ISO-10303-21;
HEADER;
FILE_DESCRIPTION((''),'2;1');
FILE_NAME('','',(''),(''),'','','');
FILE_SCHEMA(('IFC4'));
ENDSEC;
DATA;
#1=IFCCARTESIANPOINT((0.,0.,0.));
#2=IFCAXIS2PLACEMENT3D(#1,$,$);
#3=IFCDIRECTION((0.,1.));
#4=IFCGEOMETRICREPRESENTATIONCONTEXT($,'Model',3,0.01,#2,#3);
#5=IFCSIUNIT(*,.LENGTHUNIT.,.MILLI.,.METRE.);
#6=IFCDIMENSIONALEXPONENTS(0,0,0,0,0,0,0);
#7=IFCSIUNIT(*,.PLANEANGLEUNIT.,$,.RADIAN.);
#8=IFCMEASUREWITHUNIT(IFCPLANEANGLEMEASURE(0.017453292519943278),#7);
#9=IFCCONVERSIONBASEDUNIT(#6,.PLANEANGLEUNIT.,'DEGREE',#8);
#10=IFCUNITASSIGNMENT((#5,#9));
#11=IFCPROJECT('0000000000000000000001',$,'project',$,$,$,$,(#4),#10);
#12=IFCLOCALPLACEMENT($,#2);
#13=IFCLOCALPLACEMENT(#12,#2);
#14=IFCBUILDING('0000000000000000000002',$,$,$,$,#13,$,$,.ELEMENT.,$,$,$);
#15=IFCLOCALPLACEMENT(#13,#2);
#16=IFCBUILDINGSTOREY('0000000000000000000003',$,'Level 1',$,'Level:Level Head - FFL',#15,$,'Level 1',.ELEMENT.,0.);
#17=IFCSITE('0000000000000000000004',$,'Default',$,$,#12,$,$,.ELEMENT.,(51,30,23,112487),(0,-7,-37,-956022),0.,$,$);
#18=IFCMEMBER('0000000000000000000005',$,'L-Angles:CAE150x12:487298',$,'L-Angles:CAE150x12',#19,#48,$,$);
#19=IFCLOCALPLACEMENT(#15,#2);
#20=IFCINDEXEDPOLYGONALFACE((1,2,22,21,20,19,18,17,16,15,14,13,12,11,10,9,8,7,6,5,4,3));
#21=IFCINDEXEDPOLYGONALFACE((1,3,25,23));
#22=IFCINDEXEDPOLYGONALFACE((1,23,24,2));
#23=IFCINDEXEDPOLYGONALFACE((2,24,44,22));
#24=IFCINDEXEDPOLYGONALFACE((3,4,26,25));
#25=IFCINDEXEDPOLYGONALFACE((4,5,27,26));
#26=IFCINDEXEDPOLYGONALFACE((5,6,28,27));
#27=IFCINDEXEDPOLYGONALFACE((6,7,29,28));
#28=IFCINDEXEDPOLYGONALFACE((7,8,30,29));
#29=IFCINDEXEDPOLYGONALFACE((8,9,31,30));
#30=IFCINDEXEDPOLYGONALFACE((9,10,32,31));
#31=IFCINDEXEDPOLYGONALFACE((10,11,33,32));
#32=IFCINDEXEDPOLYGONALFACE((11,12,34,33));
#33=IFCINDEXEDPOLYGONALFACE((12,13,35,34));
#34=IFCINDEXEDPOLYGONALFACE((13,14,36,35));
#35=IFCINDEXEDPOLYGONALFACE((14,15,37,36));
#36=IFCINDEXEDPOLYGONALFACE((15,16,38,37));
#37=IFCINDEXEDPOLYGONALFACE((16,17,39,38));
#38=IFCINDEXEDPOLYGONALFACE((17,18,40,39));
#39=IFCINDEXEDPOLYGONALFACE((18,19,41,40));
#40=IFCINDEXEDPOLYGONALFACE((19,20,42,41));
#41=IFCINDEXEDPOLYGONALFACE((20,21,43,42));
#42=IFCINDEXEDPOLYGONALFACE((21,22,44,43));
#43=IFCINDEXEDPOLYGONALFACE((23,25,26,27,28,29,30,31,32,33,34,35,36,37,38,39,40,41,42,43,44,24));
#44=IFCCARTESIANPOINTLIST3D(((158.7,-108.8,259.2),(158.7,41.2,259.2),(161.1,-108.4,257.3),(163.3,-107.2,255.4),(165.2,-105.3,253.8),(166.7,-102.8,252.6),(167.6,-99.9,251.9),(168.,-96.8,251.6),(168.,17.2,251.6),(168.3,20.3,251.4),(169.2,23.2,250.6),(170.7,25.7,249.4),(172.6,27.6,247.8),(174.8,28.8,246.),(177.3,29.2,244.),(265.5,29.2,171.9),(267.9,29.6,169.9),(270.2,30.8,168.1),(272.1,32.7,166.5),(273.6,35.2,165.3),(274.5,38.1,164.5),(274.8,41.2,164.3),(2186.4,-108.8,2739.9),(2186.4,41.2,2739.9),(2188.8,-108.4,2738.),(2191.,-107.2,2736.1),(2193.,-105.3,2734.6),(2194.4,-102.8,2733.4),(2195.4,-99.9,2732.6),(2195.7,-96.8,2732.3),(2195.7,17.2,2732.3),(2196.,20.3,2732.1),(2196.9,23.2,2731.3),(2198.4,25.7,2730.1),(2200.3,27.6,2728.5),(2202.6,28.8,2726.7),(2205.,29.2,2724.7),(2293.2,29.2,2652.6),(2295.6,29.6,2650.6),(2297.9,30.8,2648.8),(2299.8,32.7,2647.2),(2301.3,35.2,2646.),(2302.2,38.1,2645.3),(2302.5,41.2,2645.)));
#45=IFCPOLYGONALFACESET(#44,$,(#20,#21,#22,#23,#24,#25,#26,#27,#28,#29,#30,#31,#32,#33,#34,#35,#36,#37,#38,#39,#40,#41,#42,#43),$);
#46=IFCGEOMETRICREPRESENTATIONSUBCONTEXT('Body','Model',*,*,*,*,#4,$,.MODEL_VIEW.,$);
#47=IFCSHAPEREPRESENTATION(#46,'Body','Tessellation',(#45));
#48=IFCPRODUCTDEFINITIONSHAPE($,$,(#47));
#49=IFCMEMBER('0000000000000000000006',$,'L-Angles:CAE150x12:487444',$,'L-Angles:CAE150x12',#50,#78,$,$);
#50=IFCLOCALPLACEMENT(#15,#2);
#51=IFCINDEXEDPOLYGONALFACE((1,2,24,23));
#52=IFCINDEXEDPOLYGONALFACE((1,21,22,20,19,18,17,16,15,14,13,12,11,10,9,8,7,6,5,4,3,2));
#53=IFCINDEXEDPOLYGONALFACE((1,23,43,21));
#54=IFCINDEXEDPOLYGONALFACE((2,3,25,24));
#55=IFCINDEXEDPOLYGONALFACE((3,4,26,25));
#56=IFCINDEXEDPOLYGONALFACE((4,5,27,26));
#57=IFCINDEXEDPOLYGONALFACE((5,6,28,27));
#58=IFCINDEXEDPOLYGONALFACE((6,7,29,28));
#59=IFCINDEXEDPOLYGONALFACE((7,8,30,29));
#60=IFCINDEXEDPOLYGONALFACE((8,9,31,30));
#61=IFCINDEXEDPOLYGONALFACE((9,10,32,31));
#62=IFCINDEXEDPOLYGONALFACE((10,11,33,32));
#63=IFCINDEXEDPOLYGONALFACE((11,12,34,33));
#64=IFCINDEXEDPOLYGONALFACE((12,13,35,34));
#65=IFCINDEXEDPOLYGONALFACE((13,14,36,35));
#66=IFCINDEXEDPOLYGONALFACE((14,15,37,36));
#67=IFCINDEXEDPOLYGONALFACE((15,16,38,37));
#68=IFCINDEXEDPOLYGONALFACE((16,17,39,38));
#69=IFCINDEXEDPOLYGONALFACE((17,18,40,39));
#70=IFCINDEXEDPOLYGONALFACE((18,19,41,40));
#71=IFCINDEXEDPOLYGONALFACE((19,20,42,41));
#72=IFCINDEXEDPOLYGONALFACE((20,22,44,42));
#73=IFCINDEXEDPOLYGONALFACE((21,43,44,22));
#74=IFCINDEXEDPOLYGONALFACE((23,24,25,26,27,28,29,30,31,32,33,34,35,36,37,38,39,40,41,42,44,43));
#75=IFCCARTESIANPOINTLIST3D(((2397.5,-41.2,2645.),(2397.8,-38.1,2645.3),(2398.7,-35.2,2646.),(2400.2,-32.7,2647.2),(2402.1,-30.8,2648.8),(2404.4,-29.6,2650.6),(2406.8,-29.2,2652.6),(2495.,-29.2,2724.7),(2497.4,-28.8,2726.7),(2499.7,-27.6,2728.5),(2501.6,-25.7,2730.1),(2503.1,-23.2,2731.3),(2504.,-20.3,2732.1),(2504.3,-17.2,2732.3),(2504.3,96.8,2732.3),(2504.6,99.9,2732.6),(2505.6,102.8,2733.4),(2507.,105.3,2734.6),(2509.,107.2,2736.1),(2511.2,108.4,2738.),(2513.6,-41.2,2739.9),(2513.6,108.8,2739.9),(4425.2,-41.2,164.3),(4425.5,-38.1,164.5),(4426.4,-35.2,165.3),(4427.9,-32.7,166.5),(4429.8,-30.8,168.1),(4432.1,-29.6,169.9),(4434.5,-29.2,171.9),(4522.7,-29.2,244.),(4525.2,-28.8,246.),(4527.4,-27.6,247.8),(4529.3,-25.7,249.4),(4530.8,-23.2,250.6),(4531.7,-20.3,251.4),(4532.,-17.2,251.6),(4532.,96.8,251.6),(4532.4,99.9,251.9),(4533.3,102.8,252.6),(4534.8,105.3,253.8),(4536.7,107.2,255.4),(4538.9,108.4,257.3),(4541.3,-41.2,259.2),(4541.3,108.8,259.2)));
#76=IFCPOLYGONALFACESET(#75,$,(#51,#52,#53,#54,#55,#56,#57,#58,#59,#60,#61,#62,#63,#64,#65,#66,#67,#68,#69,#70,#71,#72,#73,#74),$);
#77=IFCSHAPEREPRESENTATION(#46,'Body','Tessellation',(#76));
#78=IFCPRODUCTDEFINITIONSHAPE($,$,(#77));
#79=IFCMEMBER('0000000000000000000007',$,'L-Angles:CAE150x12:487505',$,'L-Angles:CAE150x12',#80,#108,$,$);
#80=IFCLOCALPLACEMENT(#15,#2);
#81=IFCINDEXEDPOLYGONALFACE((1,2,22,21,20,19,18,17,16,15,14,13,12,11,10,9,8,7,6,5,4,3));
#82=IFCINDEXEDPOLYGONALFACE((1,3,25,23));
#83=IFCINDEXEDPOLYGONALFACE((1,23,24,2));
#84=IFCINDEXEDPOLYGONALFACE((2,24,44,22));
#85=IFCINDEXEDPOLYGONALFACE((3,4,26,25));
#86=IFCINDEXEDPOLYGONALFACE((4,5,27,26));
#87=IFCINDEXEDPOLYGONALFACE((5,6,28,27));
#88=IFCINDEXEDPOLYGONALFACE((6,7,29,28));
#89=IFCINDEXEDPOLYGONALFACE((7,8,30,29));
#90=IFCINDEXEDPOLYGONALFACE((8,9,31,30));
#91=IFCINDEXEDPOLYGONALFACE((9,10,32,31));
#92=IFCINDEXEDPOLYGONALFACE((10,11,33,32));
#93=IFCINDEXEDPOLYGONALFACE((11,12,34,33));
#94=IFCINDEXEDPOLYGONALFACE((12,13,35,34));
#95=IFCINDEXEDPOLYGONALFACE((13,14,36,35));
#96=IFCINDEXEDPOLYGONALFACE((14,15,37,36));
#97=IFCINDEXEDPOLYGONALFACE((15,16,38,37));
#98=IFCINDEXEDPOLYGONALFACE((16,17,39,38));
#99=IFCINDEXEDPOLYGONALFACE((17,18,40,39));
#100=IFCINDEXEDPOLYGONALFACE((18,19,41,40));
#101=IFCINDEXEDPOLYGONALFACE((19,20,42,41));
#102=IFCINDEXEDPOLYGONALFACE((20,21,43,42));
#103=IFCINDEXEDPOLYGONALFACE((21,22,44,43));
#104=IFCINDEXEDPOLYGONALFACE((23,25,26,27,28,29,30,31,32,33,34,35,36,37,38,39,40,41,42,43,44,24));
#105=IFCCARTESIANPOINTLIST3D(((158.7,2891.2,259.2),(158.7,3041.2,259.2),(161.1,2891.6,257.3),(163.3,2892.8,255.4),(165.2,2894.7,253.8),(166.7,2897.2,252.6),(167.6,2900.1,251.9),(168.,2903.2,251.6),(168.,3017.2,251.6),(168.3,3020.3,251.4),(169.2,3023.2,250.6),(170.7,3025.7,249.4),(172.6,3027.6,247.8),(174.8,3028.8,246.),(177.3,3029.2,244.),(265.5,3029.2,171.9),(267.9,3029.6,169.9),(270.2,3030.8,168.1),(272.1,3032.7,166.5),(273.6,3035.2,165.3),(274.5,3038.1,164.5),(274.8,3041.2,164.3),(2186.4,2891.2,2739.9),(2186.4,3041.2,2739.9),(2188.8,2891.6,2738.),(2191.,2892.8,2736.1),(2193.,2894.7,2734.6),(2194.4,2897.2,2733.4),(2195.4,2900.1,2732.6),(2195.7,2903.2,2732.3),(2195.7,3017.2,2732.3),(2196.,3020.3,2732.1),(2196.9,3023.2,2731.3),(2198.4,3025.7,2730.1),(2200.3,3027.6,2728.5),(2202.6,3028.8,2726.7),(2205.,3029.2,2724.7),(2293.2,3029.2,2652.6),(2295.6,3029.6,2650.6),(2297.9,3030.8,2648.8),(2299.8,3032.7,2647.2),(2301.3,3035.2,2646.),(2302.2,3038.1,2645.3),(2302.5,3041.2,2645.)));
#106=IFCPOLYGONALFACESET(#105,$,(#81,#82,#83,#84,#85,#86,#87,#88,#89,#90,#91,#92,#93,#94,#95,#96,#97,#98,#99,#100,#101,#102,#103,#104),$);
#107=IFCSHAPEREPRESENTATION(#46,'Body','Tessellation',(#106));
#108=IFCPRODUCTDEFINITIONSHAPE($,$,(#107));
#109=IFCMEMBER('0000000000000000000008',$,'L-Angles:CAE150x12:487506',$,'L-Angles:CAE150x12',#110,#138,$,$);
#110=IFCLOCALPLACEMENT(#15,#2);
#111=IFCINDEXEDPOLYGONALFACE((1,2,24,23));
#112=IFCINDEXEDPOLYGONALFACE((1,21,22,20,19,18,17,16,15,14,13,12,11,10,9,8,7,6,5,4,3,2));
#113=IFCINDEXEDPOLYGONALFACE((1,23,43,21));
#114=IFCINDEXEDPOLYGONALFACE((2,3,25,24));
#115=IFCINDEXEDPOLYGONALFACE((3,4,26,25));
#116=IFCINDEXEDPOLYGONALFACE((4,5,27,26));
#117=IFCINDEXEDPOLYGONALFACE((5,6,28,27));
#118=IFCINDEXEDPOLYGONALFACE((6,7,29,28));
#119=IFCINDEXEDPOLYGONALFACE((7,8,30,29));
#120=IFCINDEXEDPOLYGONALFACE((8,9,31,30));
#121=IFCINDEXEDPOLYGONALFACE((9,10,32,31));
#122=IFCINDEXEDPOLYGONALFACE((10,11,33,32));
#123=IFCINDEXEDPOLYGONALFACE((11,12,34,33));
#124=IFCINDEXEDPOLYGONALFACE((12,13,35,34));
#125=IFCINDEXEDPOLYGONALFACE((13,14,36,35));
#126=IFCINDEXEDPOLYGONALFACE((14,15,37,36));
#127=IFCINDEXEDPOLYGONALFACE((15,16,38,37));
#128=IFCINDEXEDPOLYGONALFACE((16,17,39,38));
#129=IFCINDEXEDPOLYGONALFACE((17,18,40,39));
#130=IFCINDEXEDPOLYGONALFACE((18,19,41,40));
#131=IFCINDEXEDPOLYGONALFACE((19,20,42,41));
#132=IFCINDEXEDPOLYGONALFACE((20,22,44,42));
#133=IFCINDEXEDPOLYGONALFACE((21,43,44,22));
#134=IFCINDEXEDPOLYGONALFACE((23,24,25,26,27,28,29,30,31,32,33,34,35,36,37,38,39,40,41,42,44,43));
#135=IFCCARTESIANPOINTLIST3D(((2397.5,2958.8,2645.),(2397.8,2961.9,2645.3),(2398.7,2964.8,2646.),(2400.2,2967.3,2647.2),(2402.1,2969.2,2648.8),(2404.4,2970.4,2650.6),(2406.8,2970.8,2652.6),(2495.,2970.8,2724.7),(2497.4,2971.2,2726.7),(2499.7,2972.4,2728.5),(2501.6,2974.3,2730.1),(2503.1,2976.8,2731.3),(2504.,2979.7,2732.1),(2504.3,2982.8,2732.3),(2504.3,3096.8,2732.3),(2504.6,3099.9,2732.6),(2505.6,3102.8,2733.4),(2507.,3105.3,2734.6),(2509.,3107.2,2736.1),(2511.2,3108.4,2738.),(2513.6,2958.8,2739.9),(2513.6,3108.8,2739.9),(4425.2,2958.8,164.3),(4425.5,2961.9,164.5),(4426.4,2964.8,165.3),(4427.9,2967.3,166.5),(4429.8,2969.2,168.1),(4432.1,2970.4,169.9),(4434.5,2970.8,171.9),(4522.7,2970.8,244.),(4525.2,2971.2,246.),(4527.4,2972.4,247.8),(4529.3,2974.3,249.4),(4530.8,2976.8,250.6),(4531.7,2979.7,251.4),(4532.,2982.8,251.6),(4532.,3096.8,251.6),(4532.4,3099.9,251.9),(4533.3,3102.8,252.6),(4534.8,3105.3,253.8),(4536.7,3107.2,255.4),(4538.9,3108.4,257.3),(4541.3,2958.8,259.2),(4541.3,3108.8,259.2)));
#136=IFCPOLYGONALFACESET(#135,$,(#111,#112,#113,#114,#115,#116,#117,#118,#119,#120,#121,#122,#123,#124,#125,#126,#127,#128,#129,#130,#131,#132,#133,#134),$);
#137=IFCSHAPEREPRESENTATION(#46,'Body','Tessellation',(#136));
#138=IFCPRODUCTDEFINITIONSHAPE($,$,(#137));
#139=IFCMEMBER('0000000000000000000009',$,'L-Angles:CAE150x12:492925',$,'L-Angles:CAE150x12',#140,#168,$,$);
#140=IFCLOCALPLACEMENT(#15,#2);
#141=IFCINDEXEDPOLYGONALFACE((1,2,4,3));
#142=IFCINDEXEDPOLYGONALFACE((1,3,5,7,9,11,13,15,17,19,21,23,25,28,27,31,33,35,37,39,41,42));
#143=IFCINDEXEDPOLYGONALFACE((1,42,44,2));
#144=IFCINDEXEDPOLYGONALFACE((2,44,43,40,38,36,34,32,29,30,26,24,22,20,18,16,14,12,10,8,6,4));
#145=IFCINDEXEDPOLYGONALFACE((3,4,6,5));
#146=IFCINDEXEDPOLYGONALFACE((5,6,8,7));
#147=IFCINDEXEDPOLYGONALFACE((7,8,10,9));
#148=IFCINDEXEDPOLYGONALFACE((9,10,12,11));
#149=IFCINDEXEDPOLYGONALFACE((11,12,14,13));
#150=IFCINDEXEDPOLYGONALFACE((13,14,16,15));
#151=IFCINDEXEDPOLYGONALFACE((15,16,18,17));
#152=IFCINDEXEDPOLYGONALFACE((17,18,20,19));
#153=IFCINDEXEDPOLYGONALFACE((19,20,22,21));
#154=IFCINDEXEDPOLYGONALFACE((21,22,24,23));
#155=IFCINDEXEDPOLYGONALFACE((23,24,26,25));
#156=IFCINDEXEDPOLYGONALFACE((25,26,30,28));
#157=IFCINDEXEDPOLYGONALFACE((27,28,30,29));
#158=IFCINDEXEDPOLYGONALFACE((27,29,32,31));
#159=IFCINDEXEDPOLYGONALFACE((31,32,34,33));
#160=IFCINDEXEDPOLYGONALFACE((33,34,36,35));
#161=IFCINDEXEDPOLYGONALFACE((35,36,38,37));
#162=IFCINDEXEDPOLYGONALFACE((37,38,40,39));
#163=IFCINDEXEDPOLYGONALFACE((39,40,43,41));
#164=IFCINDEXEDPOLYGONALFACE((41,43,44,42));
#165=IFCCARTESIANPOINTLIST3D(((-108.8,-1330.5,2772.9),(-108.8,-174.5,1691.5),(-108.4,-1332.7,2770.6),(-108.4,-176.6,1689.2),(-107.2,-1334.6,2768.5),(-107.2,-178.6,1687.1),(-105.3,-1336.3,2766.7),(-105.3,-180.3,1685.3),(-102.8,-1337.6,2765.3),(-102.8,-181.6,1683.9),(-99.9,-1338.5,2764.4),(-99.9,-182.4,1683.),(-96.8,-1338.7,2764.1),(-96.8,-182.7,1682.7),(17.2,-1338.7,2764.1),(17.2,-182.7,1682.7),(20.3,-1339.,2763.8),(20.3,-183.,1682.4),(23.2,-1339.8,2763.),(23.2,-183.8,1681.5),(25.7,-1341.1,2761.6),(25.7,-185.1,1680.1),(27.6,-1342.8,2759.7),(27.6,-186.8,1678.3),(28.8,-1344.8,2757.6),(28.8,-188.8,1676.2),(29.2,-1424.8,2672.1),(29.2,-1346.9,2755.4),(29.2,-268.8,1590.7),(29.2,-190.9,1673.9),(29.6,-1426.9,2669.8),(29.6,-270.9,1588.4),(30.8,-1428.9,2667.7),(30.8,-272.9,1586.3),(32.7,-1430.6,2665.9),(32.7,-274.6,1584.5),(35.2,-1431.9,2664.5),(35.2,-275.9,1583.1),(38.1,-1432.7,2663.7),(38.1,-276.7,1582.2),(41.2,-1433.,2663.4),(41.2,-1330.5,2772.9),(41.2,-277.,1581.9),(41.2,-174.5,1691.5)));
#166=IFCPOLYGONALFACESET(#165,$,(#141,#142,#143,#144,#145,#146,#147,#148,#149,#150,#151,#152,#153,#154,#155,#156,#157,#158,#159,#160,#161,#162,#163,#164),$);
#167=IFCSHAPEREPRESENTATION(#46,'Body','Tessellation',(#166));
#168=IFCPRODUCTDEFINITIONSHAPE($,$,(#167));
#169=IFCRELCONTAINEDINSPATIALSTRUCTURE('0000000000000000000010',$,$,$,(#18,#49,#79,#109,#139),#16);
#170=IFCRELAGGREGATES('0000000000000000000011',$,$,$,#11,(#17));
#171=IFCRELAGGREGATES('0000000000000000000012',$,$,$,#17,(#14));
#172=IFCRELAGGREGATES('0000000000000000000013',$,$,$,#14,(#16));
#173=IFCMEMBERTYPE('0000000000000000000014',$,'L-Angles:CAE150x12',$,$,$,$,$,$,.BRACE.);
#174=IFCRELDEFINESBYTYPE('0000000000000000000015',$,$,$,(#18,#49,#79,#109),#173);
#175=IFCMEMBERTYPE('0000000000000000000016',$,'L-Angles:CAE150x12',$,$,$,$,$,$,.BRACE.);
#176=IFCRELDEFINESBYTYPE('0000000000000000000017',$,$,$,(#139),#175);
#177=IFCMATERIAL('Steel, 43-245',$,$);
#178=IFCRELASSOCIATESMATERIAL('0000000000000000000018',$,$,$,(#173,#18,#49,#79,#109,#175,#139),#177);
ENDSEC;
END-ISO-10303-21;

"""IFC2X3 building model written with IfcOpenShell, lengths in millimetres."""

from ifc_helpers import new_model, entity, si_unit, converted_unit, direction, frame, frame_2d, origin, place, context, subcontext, project, spatial, polyline, circle_curve, parameter, trimmed, segment, composite_curve, outline, extrude, source, transform, mapped, material, type_object, type_shapes, element, save


model = new_model("IFC2X3")

# Units and contexts
model_context = context("Model", 3, precision=0.01, world=origin(), true_north=direction((0.0, 1.0)))
body_context = subcontext(model_context, "Body", "Model", "MODEL_VIEW")
ifc_project = project(units=[si_unit("LENGTHUNIT", "METRE", prefix="MILLI"), converted_unit("PLANEANGLEUNIT", "DEGREE", entity("IfcPlaneAngleMeasure", 0.017453292519943278), si_unit("PLANEANGLEUNIT", "RADIAN"), dimensions=[0, 0, 0, 0, 0, 0, 0])], contexts=[model_context])

# Site, building, storey
site_placement = place(None, origin())
site = spatial("IfcSite", under=ifc_project, at=site_placement, Name="Default", CompositionType="ELEMENT", RefLatitude=(51, 30, 23, 112487), RefLongitude=(0, -7, -37, -956022), RefElevation=0.0)
building_placement = place(site_placement, origin())
building = spatial("IfcBuilding", under=site, at=building_placement, CompositionType="ELEMENT")
storey_placement = place(building_placement, origin())
storey = spatial("IfcBuildingStorey", under=building, at=storey_placement, Name="Level 1", ObjectType="Level:Level Head - FFL", LongName="Level 1", CompositionType="ELEMENT", Elevation=0.0)

# Shared definitions
ifc_material = material(Name="Steel, 43-245")

# Members
member_type_1 = type_object("IfcMemberType", Name="L-Angles:CAE150x12", PredefinedType="BRACE", material=ifc_material)
shared_shape_1 = source(origin(), body_context, "Body", "SweptSolid", [
    extrude(outline(composite_curve([segment(polyline([(-102.0, -48.0), (48.0, -48.0)]), True, "CONTINUOUS"), segment(polyline([(48.0, -48.0), (48.0, 102.0)]), True, "CONTINUOUS"), segment(trimmed(circle_curve(frame_2d((48.0, 90.0), x_axis=(0.0, 1.0)), 12.0), [parameter(0.0)], [parameter(90.0)], True, "PARAMETER"), True, "CONTINUOUS"), segment(polyline([(36.0, 90.0), (36.0, -24.0)]), True, "CONTINUOUS"), segment(trimmed(circle_curve(frame_2d((24.0, -24.0), x_axis=(1.0, 0.0)), 12.0), [parameter(270.0)], [parameter(0.0)], True, "PARAMETER"), False, "CONTINUOUS"), segment(polyline([(24.0, -36.0), (-90.0, -36.0)]), True, "CONTINUOUS"), segment(trimmed(circle_curve(frame_2d((-90.0, -48.0), x_axis=(0.0, 1.0)), 12.0), [parameter(0.0)], [parameter(90.0)], True, "PARAMETER"), True, "CONTINUOUS")], self_intersect=False)), frame((-1555.5, -6.8, -6.8), z_axis=(1.0, 0.0, 0.0), x_axis=(0.0, 0.0, 1.0)), (0.0, 0.0, 1.0), 3204.0),
])
type_shapes(member_type_1, [shared_shape_1])
for number, where, z_axis, x_axis, name in (
    (1, (1175.0, 0.0, 1437.5), (-0.774257, 0.0, 0.632871), (0.632871, 0.0, 0.774257), "L-Angles:CAE150x12:487298"),
    (2, (3525.0, 0.0, 1437.5), (0.774257, 0.0, 0.632871), (-0.632871, 0.0, 0.774257), "L-Angles:CAE150x12:487444"),
    (3, (1175.0, 3000.0, 1437.5), (-0.774257, 0.0, 0.632871), (0.632871, 0.0, 0.774257), "L-Angles:CAE150x12:487505"),
    (4, (3525.0, 3000.0, 1437.5), (0.774257, 0.0, 0.632871), (-0.632871, 0.0, 0.774257), "L-Angles:CAE150x12:487506"),
):
    element("IfcMember", number, at=place(storey_placement, frame(where, z_axis=z_axis, x_axis=x_axis)), inside=storey, type_object=member_type_1, material=ifc_material, Name=name, ObjectType="L-Angles:CAE150x12", context=body_context, shape_type="MappedRepresentation", body=[
        mapped(shared_shape_1, transform((0.0, 0.0, 0.0), scale=1.0)),
    ])
member_type_2 = type_object("IfcMemberType", Name="L-Angles:CAE150x12", PredefinedType="BRACE", material=ifc_material)
shared_shape_2 = source(origin(), body_context, "Body", "SweptSolid", [
    extrude(outline(composite_curve([segment(polyline([(-102.0, -48.0), (48.0, -48.0)]), True, "CONTINUOUS"), segment(polyline([(48.0, -48.0), (48.0, 102.0)]), True, "CONTINUOUS"), segment(trimmed(circle_curve(frame_2d((48.0, 90.0), x_axis=(0.0, 1.0)), 12.0), [parameter(0.0)], [parameter(90.0)], True, "PARAMETER"), True, "CONTINUOUS"), segment(polyline([(36.0, 90.0), (36.0, -24.0)]), True, "CONTINUOUS"), segment(trimmed(circle_curve(frame_2d((24.0, -24.0), x_axis=(1.0, 0.0)), 12.0), [parameter(270.0)], [parameter(0.0)], True, "PARAMETER"), False, "CONTINUOUS"), segment(polyline([(24.0, -36.0), (-90.0, -36.0)]), True, "CONTINUOUS"), segment(trimmed(circle_curve(frame_2d((-90.0, -48.0), x_axis=(0.0, 1.0)), 12.0), [parameter(0.0)], [parameter(90.0)], True, "PARAMETER"), True, "CONTINUOUS")], self_intersect=False)), frame((-749.5, -6.8, -6.8), z_axis=(1.0, 0.0, 0.0), x_axis=(0.0, 0.0, 1.0)), (0.0, 0.0, 1.0), 1583.0),
])
type_shapes(member_type_2, [shared_shape_2])
member_1_placement = place(storey_placement, frame((0.0, -750.0, 2173.4), z_axis=(0.0, 0.68315, 0.730278), x_axis=(0.0, -0.730278, 0.68315)))
element("IfcMember", 5, at=member_1_placement, inside=storey, type_object=member_type_2, material=ifc_material, Name="L-Angles:CAE150x12:492925", ObjectType="L-Angles:CAE150x12", context=body_context, shape_type="MappedRepresentation", body=[
    mapped(shared_shape_2, transform((0.0, 0.0, 0.0), scale=1.0)),
])

save(model, "model.ifc")
